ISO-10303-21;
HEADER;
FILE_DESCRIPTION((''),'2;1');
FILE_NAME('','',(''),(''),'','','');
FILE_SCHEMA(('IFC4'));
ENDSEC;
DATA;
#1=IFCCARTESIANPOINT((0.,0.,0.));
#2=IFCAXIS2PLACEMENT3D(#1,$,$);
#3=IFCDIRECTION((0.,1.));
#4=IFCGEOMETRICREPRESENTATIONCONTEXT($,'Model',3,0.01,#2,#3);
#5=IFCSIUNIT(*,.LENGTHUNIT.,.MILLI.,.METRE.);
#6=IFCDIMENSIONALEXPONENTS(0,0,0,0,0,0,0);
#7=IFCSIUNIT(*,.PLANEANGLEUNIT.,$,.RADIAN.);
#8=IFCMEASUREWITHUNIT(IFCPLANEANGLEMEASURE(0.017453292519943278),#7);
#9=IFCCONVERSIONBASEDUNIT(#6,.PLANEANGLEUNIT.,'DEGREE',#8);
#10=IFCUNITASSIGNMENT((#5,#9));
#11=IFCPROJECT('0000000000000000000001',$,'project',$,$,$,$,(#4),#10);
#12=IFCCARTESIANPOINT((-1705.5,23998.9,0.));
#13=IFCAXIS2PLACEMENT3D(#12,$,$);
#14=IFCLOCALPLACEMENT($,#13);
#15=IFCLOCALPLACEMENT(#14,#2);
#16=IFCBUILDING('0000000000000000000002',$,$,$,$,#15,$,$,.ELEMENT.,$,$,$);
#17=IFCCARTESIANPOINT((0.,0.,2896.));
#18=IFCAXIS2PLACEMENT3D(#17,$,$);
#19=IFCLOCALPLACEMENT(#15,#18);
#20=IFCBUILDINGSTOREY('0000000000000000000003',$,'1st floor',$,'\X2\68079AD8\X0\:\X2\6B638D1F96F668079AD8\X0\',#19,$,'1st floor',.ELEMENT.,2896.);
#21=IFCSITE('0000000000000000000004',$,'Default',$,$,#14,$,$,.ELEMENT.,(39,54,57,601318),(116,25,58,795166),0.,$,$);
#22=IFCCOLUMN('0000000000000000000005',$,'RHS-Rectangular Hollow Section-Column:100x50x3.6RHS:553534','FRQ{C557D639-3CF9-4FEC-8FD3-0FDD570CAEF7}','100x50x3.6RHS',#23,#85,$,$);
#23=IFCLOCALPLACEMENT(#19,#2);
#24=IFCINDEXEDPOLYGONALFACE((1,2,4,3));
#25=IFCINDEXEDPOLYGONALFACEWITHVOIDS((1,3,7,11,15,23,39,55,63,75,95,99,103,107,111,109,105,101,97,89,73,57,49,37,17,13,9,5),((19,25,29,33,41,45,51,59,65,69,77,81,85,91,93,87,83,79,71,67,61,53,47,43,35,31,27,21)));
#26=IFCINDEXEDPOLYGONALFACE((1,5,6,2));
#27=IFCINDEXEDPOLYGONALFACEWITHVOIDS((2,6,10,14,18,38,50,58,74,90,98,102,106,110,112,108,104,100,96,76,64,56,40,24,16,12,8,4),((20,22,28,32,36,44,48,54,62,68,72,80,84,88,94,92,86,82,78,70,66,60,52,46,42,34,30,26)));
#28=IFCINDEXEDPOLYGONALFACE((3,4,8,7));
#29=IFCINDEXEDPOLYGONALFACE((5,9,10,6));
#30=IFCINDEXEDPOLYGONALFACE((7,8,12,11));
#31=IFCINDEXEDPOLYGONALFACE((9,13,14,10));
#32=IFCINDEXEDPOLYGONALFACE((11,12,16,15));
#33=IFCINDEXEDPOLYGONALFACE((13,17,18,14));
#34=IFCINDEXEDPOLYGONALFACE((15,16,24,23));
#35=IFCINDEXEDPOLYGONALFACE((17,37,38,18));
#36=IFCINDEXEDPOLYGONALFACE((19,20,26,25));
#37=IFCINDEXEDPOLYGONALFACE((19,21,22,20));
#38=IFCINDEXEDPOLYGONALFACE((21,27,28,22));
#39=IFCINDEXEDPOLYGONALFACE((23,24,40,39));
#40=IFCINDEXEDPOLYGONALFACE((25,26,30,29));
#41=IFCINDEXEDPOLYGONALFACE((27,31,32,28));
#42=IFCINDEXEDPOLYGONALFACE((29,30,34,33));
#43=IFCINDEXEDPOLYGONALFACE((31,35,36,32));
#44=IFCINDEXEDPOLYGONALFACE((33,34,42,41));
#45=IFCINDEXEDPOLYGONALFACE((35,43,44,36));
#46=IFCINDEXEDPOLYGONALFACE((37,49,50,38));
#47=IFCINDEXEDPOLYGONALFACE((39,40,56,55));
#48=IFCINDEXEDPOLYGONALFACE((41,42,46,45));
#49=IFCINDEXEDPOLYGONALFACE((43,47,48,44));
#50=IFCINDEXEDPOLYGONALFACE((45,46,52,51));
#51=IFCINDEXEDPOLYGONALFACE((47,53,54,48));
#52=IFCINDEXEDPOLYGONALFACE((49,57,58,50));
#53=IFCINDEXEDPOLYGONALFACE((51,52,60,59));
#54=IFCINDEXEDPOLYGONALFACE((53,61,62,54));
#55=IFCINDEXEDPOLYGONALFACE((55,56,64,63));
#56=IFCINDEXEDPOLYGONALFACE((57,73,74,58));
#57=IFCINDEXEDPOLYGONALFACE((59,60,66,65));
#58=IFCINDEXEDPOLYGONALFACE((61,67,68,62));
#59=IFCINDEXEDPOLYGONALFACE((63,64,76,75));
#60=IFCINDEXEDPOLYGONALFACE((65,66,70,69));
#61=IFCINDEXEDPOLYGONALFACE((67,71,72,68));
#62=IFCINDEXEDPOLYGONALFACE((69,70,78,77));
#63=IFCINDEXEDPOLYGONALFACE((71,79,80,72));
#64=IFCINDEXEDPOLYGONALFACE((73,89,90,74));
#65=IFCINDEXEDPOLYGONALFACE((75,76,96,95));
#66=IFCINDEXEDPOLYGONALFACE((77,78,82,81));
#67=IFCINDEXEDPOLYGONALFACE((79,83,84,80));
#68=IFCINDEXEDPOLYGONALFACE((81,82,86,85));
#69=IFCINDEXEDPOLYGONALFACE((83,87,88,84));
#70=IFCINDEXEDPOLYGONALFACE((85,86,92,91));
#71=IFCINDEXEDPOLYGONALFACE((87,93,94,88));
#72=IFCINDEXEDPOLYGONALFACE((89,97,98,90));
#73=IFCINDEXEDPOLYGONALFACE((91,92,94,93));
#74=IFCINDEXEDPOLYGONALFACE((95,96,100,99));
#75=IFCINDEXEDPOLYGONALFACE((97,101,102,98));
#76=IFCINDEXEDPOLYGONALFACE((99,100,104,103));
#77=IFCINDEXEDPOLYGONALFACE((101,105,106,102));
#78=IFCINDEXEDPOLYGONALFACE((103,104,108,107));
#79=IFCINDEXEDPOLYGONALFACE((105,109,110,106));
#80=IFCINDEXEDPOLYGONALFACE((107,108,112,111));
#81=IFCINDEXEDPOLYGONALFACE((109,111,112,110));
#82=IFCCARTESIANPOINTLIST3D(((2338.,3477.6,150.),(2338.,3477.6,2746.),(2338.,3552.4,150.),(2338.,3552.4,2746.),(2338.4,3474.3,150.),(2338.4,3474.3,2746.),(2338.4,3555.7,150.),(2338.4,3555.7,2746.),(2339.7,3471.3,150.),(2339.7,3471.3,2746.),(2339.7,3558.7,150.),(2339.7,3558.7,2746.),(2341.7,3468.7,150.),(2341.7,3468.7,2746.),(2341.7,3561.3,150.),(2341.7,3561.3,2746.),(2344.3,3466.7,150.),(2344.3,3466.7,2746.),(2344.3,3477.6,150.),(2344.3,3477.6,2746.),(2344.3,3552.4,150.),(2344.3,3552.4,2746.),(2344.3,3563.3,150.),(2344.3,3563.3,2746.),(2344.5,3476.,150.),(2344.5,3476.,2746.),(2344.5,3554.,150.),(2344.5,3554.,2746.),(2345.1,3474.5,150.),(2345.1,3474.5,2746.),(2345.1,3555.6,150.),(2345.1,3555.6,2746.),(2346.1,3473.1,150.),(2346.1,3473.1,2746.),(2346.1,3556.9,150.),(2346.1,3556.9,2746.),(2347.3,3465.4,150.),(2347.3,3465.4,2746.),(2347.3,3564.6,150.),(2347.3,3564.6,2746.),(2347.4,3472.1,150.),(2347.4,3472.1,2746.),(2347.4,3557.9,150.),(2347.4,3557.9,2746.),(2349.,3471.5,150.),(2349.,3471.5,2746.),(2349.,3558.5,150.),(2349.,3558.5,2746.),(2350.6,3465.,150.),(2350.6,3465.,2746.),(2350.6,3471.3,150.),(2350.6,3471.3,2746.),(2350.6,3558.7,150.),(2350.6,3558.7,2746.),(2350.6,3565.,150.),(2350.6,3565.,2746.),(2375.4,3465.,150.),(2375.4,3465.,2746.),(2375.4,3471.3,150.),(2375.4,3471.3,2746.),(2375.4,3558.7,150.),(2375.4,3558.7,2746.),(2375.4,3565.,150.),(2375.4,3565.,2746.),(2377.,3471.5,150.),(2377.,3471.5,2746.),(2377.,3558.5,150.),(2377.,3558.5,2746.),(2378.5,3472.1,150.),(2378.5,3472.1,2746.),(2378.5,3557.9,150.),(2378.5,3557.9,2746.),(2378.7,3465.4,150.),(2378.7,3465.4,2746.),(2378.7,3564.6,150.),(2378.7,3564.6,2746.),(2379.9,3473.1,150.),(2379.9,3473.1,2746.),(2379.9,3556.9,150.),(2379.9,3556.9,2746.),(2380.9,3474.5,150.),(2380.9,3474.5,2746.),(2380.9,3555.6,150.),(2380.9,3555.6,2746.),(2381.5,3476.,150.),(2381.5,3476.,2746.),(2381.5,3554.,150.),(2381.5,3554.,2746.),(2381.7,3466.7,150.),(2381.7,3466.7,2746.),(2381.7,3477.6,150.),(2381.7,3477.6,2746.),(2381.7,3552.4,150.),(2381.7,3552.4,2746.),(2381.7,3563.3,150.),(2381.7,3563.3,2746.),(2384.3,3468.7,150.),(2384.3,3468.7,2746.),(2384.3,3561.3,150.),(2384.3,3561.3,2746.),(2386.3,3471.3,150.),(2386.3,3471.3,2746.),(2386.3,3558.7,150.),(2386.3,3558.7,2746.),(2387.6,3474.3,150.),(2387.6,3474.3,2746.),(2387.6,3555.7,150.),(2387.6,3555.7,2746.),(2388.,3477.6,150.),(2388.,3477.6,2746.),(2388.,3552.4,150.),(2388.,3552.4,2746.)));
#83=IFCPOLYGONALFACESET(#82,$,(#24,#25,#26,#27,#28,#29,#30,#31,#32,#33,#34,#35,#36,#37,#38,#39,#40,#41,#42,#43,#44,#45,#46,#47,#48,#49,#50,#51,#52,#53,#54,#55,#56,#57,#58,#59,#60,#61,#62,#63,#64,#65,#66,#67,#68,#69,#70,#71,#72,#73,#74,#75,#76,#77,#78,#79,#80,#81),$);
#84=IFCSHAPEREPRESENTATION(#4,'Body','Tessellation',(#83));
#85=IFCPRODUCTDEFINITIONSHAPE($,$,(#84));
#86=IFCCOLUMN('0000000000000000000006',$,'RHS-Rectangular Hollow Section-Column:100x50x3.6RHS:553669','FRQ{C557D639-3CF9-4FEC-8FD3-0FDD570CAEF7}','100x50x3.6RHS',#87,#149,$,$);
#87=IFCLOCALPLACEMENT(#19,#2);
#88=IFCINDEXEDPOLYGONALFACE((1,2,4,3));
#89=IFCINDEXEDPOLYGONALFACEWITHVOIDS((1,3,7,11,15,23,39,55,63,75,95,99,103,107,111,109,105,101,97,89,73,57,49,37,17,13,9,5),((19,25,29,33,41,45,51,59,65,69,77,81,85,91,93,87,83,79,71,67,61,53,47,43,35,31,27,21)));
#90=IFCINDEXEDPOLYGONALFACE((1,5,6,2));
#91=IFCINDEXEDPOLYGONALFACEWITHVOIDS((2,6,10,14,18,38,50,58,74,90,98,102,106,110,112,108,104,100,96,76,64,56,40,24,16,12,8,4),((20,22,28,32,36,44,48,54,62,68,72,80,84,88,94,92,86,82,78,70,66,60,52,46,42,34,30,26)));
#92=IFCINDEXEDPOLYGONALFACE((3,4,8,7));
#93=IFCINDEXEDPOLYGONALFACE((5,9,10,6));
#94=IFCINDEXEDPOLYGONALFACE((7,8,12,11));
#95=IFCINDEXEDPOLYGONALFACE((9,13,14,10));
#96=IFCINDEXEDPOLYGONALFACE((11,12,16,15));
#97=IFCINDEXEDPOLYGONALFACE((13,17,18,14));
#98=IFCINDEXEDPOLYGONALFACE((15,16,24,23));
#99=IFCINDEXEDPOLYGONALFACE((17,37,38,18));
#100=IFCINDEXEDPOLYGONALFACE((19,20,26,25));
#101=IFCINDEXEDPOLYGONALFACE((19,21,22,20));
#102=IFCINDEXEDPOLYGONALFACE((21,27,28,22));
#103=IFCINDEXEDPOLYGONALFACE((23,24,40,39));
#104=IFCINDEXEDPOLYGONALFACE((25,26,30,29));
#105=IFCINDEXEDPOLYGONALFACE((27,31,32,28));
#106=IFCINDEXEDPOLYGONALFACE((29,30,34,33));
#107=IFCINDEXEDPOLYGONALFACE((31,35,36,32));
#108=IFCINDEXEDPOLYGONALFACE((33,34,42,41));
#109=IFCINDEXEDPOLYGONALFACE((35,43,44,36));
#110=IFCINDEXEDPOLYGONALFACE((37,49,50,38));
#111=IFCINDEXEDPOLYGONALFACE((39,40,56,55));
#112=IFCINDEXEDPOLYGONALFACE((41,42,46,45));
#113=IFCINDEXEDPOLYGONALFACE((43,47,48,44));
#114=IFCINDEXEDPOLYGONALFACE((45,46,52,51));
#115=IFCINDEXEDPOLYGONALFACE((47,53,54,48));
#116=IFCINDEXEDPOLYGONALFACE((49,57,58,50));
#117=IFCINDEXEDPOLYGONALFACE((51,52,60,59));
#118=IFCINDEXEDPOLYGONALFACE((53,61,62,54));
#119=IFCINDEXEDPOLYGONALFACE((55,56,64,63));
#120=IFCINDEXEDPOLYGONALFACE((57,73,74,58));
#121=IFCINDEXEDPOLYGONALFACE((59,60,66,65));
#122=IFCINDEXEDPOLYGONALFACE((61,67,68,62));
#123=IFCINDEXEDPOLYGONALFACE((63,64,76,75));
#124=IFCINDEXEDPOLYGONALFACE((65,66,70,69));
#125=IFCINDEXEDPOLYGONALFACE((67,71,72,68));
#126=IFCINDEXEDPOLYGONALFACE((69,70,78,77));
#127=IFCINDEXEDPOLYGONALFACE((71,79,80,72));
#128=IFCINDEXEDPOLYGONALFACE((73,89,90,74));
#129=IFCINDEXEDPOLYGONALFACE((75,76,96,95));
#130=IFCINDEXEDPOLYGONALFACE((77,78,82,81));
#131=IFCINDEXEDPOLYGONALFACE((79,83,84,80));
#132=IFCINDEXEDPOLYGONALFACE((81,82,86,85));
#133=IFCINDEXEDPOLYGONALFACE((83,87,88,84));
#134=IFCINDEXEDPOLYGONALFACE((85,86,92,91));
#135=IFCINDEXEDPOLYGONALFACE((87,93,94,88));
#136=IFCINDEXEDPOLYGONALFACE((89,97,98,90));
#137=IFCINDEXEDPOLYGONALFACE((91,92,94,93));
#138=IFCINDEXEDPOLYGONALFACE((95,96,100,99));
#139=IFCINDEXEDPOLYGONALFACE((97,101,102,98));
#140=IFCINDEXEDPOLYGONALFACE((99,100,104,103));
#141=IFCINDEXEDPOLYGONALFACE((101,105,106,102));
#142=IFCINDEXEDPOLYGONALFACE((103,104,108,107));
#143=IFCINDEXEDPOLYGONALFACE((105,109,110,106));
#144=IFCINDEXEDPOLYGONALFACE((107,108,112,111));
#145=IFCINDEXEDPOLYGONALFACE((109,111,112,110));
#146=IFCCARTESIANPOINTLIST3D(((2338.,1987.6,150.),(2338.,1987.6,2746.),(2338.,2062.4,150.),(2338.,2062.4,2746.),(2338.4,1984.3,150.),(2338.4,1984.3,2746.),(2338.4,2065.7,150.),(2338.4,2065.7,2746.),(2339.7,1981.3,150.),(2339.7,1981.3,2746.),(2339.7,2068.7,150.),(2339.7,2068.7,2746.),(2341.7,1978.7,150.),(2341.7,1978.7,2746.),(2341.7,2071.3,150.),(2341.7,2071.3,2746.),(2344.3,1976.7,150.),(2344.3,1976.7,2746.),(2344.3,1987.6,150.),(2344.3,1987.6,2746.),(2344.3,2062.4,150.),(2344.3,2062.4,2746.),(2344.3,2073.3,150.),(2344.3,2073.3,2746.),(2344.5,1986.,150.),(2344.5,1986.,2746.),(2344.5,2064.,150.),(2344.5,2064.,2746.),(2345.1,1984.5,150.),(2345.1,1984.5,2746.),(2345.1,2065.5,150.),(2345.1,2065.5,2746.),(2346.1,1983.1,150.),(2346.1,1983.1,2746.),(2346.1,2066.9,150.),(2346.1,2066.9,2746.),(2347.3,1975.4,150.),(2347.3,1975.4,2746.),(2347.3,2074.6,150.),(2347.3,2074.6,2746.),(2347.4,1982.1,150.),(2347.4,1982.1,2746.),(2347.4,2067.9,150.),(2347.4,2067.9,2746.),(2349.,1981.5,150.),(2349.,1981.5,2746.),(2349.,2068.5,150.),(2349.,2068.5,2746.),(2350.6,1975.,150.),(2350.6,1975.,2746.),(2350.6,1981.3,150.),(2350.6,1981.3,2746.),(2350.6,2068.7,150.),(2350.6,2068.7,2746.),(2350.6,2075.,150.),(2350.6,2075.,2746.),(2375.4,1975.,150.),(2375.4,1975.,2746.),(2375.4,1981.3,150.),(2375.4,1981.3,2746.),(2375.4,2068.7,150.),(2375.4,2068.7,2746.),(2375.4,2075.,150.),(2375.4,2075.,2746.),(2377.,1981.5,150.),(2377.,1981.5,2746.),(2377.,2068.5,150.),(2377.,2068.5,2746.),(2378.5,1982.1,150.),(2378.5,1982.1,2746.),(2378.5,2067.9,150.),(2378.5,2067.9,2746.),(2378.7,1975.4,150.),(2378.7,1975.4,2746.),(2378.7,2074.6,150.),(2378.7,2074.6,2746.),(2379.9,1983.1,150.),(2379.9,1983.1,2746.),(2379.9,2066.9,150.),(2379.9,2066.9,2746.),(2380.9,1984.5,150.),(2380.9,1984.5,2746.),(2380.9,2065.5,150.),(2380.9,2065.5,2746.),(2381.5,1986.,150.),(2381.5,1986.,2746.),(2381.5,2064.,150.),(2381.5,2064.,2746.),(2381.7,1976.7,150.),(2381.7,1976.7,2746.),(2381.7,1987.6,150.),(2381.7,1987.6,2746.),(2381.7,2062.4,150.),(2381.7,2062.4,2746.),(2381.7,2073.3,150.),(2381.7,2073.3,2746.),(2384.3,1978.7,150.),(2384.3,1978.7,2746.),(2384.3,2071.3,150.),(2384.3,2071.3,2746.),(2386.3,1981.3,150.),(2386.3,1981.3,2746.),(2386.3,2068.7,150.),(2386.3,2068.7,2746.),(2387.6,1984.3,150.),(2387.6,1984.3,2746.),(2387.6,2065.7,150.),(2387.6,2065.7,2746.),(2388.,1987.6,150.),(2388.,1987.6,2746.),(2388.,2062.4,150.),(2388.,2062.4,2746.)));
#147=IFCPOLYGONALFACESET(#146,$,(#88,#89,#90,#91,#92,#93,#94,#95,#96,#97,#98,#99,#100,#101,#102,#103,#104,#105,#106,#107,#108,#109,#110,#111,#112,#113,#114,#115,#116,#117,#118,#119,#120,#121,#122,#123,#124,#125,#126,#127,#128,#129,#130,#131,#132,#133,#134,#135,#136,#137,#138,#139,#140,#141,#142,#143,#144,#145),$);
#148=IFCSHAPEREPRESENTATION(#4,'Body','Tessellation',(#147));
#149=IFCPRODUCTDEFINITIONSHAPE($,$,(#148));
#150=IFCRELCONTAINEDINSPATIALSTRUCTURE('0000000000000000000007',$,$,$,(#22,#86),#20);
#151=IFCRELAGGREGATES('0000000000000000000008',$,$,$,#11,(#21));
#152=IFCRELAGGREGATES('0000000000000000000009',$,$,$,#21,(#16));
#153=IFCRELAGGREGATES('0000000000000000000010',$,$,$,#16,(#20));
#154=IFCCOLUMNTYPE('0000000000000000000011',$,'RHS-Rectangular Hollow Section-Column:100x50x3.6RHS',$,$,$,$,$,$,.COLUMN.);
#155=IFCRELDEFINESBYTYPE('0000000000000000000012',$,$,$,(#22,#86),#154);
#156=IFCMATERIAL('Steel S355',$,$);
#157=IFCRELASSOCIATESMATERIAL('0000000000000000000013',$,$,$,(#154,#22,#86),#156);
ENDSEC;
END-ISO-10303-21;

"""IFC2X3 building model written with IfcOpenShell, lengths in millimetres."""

from ifc_helpers import new_model, entity, si_unit, converted_unit, direction, frame, origin, origin_2d, place, context, project, spatial, hollow_rectangle, extrude, clip, halfspace, material, type_object, element, save


model = new_model("IFC2X3")

# Units and contexts
model_context = context("Model", 3, precision=0.01, world=origin(), true_north=direction((0.0, 1.0)))
ifc_project = project(units=[si_unit("LENGTHUNIT", "METRE", prefix="MILLI"), converted_unit("PLANEANGLEUNIT", "DEGREE", entity("IfcPlaneAngleMeasure", 0.017453292519943278), si_unit("PLANEANGLEUNIT", "RADIAN"), dimensions=[0, 0, 0, 0, 0, 0, 0])], contexts=[model_context])

# Site, building, storey
site_placement = place(None, frame((-1705.5, 23998.9, 0.0)))
site = spatial("IfcSite", under=ifc_project, at=site_placement, Name="Default", CompositionType="ELEMENT", RefLatitude=(39, 54, 57, 601318), RefLongitude=(116, 25, 58, 795166), RefElevation=0.0)
building_placement = place(site_placement, origin())
building = spatial("IfcBuilding", under=site, at=building_placement, CompositionType="ELEMENT")
storey_placement = place(building_placement, frame((0.0, 0.0, 2896.0)))
storey = spatial("IfcBuildingStorey", under=building, at=storey_placement, Name="1st floor", ObjectType="标高:正负零标高", LongName="1st floor", CompositionType="ELEMENT", Elevation=2896.0)

# Shared definitions
ifc_material_1 = material(Name="Steel S355")

# Columns
column_type_1 = type_object("IfcColumnType", Name="RHS-Rectangular Hollow Section-Column:100x50x3.6RHS", PredefinedType="COLUMN", material=ifc_material_1)
column_1_placement = place(storey_placement, frame((2363.0, 3515.0, 2746.0), z_axis=(0.0, 0.0, 1.0), x_axis=(-1.0, 0.0, 0.0)))
element("IfcColumn", 1, at=column_1_placement, inside=storey, type_object=column_type_1, material=ifc_material_1, Name="RHS-Rectangular Hollow Section-Column:100x50x3.6RHS:553534", Description="FRQ{C557D639-3CF9-4FEC-8FD3-0FDD570CAEF7}", ObjectType="100x50x3.6RHS", context=model_context, shape_type="Clipping", body=[
    clip(extrude(hollow_rectangle(XDim=50.0, YDim=100.0, WallThickness=6.3, InnerFilletRadius=6.3, OuterFilletRadius=12.6, at=origin_2d()), origin(), (0.0, 0.0, -1.0), 2651.9), halfspace(frame((2363.0, 3515.0, -2596.0), z_axis=(0.0, 0.0, 1.0), x_axis=(-1.0, 0.0, 0.0)), True)),
])
column_2_placement = place(storey_placement, frame((2363.0, 2025.0, 2746.0), z_axis=(0.0, 0.0, 1.0), x_axis=(-1.0, 0.0, 0.0)))
element("IfcColumn", 2, at=column_2_placement, inside=storey, type_object=column_type_1, material=ifc_material_1, Name="RHS-Rectangular Hollow Section-Column:100x50x3.6RHS:553669", Description="FRQ{C557D639-3CF9-4FEC-8FD3-0FDD570CAEF7}", ObjectType="100x50x3.6RHS", context=model_context, shape_type="Clipping", body=[
    clip(extrude(hollow_rectangle(XDim=50.0, YDim=100.0, WallThickness=6.3, InnerFilletRadius=6.3, OuterFilletRadius=12.6, at=origin_2d()), origin(), (0.0, 0.0, -1.0), 2651.9), halfspace(frame((2363.0, 2025.0, -2596.0), z_axis=(0.0, 0.0, 1.0), x_axis=(-1.0, 0.0, 0.0)), True)),
])

save(model, "model.ifc")
